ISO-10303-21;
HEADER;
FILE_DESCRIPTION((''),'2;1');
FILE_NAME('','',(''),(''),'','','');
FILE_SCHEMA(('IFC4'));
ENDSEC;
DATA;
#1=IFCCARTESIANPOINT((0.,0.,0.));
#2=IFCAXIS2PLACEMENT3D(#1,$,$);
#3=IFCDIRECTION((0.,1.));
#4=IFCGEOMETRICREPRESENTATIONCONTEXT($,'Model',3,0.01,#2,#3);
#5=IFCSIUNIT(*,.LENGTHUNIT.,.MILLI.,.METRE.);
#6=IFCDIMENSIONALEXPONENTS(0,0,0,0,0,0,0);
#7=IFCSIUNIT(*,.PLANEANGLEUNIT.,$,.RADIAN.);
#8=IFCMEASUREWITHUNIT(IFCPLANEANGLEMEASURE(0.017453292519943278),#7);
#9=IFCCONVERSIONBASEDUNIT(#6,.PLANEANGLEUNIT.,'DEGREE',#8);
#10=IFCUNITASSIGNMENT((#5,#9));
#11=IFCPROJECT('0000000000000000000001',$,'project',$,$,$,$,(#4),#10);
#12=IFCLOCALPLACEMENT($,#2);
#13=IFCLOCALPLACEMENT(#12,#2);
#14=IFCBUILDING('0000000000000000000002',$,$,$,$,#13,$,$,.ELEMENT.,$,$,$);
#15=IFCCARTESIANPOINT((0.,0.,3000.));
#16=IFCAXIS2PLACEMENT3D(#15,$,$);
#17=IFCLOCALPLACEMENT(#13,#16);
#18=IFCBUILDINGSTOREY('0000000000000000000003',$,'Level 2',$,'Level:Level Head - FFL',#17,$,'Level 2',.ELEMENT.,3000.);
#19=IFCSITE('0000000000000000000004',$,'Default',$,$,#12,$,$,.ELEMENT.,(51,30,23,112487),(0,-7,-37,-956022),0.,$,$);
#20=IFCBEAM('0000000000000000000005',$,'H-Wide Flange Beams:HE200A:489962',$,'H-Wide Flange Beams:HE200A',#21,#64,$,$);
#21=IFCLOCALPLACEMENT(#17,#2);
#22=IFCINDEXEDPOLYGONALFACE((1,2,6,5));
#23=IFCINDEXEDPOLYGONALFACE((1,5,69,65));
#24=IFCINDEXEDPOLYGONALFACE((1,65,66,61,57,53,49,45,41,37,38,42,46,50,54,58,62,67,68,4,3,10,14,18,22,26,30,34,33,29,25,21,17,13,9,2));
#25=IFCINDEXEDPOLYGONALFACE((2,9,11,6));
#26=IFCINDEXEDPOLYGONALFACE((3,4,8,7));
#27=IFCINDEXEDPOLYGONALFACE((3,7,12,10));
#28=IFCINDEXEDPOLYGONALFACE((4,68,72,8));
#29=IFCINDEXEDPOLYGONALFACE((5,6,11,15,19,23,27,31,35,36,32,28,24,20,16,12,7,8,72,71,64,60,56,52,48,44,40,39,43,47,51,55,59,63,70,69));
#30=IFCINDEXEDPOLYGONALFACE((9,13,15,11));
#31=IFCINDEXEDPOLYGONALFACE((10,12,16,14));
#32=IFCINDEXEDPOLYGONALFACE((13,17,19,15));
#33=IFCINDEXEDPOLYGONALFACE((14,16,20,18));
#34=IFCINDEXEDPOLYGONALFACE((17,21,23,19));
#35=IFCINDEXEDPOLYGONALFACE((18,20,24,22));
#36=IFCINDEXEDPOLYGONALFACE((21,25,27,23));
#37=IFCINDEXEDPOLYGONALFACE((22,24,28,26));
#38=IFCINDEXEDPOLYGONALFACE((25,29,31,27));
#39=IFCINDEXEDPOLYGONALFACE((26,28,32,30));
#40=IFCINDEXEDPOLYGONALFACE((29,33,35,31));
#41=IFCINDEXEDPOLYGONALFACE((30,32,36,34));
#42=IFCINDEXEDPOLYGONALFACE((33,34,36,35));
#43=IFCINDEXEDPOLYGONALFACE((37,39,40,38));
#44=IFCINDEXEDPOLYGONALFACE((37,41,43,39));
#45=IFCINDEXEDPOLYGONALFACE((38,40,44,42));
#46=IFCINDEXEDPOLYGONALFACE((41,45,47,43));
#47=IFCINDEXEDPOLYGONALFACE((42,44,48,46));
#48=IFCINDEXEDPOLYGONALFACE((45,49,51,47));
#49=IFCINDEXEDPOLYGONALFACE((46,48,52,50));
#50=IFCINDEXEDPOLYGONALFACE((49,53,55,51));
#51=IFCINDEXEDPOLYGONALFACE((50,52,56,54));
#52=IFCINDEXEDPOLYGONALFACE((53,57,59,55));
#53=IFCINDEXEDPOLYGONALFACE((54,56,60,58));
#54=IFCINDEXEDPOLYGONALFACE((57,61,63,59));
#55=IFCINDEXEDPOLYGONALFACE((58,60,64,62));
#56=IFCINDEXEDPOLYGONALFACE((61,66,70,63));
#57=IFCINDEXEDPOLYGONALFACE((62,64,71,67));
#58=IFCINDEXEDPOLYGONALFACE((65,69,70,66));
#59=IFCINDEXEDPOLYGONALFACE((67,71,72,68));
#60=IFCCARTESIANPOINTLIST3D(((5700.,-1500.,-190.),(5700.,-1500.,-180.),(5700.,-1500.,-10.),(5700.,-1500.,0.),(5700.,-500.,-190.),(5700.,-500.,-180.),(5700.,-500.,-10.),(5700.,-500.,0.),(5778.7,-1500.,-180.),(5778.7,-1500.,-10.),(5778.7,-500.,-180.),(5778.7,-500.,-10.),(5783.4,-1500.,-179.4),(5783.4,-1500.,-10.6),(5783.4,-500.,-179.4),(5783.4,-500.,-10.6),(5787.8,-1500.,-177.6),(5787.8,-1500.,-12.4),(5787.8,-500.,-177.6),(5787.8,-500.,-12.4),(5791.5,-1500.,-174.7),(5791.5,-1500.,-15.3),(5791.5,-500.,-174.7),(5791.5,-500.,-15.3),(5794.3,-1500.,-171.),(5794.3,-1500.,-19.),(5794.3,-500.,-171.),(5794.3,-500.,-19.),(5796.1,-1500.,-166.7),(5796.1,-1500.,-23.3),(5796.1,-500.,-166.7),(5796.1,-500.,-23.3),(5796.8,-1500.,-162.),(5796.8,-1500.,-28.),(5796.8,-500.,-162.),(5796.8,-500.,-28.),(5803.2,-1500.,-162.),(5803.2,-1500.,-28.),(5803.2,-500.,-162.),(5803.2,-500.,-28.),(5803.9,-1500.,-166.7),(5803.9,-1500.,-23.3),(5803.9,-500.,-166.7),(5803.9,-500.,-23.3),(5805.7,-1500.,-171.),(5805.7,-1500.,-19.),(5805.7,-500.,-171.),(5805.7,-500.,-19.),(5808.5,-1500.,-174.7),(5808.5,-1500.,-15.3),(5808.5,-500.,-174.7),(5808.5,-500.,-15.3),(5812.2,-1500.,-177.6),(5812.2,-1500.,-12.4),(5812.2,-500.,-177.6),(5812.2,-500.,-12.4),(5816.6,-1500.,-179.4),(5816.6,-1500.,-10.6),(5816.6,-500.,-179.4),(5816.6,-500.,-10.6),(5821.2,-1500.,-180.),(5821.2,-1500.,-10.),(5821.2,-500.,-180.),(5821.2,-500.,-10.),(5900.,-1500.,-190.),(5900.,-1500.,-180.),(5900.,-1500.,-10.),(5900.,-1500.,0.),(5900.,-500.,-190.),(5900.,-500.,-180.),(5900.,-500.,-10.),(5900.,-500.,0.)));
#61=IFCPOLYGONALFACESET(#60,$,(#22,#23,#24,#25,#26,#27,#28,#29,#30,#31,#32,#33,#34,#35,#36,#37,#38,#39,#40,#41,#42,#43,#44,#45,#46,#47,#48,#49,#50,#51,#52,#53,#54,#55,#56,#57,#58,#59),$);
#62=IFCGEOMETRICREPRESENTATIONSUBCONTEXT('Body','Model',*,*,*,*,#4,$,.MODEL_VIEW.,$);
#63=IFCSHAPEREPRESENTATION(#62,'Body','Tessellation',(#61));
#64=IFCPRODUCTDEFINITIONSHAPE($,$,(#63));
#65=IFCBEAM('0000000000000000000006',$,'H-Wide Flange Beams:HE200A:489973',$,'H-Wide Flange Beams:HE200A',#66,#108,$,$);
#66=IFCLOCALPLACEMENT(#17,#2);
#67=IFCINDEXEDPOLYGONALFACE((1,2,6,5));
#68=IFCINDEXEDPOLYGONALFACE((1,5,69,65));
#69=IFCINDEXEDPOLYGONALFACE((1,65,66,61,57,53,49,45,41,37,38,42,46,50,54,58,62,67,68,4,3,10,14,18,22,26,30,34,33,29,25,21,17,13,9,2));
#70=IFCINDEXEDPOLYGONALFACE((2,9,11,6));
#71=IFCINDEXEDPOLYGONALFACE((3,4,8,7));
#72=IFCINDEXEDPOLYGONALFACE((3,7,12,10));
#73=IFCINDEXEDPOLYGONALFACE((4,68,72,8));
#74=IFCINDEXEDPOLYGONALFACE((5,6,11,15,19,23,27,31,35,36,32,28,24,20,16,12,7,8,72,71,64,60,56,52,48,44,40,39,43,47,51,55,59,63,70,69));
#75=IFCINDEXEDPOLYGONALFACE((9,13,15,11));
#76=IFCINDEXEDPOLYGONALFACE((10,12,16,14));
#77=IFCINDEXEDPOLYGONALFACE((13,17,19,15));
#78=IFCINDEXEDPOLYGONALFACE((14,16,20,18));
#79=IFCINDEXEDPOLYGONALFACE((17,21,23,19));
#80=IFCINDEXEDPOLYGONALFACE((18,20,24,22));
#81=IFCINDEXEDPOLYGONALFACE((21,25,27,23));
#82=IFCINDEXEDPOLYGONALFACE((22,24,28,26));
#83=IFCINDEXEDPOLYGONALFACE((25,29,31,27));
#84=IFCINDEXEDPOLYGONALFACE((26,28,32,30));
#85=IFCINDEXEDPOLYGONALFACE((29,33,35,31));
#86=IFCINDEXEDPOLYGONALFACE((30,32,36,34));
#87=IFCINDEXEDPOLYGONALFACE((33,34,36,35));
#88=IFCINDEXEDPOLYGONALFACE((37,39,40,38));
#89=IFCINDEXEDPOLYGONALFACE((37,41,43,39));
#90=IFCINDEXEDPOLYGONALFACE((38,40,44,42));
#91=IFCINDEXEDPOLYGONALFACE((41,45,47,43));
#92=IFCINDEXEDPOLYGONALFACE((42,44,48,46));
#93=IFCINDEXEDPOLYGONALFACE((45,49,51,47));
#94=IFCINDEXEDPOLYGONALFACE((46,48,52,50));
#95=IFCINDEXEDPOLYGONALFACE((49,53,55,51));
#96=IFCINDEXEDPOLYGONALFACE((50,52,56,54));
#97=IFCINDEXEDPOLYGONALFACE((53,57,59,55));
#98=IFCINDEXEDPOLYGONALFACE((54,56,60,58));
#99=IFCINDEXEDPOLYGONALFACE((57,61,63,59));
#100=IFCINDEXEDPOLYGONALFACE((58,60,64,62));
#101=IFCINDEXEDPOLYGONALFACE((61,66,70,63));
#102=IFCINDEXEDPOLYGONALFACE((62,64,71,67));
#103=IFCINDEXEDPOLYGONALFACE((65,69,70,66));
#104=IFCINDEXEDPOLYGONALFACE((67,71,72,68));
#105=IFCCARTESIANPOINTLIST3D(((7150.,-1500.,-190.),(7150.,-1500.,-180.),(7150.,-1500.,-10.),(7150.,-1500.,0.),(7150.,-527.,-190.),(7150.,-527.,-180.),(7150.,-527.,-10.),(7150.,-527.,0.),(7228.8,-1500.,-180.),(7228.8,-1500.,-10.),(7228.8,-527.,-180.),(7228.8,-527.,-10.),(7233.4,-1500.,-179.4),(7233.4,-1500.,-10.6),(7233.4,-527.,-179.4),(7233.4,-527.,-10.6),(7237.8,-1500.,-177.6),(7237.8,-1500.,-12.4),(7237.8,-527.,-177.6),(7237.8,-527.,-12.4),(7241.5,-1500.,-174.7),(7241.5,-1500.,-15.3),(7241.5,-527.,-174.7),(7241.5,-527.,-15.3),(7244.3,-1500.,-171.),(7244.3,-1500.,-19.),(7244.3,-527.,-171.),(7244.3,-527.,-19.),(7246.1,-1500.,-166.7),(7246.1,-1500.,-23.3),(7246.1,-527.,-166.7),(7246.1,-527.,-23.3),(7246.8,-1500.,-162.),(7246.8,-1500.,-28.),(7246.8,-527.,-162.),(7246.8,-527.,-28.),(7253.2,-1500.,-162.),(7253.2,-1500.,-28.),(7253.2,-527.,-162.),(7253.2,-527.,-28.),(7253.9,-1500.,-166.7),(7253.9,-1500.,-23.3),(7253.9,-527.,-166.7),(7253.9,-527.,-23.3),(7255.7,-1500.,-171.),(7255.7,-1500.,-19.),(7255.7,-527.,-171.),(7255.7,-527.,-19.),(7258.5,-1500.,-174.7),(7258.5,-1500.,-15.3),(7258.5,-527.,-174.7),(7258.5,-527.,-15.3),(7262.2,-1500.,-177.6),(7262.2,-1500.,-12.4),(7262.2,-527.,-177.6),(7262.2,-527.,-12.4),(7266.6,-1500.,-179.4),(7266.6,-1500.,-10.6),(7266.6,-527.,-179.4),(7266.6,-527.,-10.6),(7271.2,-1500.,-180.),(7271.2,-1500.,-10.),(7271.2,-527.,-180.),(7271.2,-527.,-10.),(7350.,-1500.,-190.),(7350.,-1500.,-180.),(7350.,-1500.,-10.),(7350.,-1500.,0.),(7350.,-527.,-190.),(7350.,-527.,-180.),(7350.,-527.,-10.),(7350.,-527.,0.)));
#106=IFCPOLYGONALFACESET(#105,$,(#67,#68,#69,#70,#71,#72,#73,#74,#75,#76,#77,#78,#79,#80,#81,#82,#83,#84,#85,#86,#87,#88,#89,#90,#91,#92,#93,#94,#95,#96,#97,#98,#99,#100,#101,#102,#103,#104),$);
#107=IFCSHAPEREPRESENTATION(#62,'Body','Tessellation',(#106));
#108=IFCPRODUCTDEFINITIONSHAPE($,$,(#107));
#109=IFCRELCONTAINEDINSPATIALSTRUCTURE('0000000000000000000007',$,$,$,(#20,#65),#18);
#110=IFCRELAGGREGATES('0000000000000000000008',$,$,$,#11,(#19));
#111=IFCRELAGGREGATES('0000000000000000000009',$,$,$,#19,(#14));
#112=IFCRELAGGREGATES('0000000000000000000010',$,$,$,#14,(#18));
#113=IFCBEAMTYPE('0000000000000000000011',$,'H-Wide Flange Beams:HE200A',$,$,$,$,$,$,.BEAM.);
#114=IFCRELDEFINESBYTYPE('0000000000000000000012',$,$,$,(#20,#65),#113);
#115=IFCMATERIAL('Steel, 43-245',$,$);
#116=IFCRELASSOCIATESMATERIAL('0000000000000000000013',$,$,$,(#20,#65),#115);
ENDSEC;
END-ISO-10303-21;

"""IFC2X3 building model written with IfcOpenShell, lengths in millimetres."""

from ifc_helpers import new_model, entity, si_unit, converted_unit, direction, frame, frame_2d, origin, place, context, subcontext, project, spatial, i_section, extrude, material, type_object, element, save


model = new_model("IFC2X3")

# Units and contexts
model_context = context("Model", 3, precision=0.01, world=origin(), true_north=direction((0.0, 1.0)))
body_context = subcontext(model_context, "Body", "Model", "MODEL_VIEW")
ifc_project = project(units=[si_unit("LENGTHUNIT", "METRE", prefix="MILLI"), converted_unit("PLANEANGLEUNIT", "DEGREE", entity("IfcPlaneAngleMeasure", 0.017453292519943278), si_unit("PLANEANGLEUNIT", "RADIAN"), dimensions=[0, 0, 0, 0, 0, 0, 0])], contexts=[model_context])

# Site, building, storey
site_placement = place(None, origin())
site = spatial("IfcSite", under=ifc_project, at=site_placement, Name="Default", CompositionType="ELEMENT", RefLatitude=(51, 30, 23, 112487), RefLongitude=(0, -7, -37, -956022), RefElevation=0.0)
building_placement = place(site_placement, origin())
building = spatial("IfcBuilding", under=site, at=building_placement, CompositionType="ELEMENT")
storey_placement = place(building_placement, frame((0.0, 0.0, 3000.0)))
storey = spatial("IfcBuildingStorey", under=building, at=storey_placement, Name="Level 2", ObjectType="Level:Level Head - FFL", LongName="Level 2", CompositionType="ELEMENT", Elevation=3000.0)

# Shared definitions
ifc_material = material(Name="Steel, 43-245")

# Beams
beam_type_1 = type_object("IfcBeamType", Name="H-Wide Flange Beams:HE200A", PredefinedType="BEAM")
beam_1_placement = place(storey_placement, frame((5800.0, -1500.0, 0.0), z_axis=(0.0, 0.0, 1.0), x_axis=(0.0, 1.0, 0.0)))
element("IfcBeam", 1, at=beam_1_placement, inside=storey, type_object=beam_type_1, material=ifc_material, Name="H-Wide Flange Beams:HE200A:489962", ObjectType="H-Wide Flange Beams:HE200A", context=body_context, shape_type="SweptSolid", body=[
    extrude(i_section(OverallWidth=200.0, OverallDepth=190.0, WebThickness=6.5, FlangeThickness=10.0, FilletRadius=18.0, at=frame_2d((0.0, 0.0), x_axis=(0.0, 1.0))), frame((0.0, 0.0, -95.0), z_axis=(1.0, 0.0, 0.0), x_axis=(0.0, 0.0, -1.0)), (0.0, 0.0, 1.0), 1000.0),
])
beam_2_placement = place(storey_placement, frame((7250.0, -1500.0, 0.0), z_axis=(0.0, 0.0, 1.0), x_axis=(0.0, 1.0, 0.0)))
element("IfcBeam", 2, at=beam_2_placement, inside=storey, type_object=beam_type_1, material=ifc_material, Name="H-Wide Flange Beams:HE200A:489973", ObjectType="H-Wide Flange Beams:HE200A", context=body_context, shape_type="SweptSolid", body=[
    extrude(i_section(OverallWidth=200.0, OverallDepth=190.0, WebThickness=6.5, FlangeThickness=10.0, FilletRadius=18.0, at=frame_2d((0.0, 0.0), x_axis=(0.0, 1.0))), frame((0.0, 0.0, -95.0), z_axis=(1.0, 0.0, 0.0), x_axis=(0.0, 0.0, -1.0)), (0.0, 0.0, 1.0), 973.0),
])

save(model, "model.ifc")
